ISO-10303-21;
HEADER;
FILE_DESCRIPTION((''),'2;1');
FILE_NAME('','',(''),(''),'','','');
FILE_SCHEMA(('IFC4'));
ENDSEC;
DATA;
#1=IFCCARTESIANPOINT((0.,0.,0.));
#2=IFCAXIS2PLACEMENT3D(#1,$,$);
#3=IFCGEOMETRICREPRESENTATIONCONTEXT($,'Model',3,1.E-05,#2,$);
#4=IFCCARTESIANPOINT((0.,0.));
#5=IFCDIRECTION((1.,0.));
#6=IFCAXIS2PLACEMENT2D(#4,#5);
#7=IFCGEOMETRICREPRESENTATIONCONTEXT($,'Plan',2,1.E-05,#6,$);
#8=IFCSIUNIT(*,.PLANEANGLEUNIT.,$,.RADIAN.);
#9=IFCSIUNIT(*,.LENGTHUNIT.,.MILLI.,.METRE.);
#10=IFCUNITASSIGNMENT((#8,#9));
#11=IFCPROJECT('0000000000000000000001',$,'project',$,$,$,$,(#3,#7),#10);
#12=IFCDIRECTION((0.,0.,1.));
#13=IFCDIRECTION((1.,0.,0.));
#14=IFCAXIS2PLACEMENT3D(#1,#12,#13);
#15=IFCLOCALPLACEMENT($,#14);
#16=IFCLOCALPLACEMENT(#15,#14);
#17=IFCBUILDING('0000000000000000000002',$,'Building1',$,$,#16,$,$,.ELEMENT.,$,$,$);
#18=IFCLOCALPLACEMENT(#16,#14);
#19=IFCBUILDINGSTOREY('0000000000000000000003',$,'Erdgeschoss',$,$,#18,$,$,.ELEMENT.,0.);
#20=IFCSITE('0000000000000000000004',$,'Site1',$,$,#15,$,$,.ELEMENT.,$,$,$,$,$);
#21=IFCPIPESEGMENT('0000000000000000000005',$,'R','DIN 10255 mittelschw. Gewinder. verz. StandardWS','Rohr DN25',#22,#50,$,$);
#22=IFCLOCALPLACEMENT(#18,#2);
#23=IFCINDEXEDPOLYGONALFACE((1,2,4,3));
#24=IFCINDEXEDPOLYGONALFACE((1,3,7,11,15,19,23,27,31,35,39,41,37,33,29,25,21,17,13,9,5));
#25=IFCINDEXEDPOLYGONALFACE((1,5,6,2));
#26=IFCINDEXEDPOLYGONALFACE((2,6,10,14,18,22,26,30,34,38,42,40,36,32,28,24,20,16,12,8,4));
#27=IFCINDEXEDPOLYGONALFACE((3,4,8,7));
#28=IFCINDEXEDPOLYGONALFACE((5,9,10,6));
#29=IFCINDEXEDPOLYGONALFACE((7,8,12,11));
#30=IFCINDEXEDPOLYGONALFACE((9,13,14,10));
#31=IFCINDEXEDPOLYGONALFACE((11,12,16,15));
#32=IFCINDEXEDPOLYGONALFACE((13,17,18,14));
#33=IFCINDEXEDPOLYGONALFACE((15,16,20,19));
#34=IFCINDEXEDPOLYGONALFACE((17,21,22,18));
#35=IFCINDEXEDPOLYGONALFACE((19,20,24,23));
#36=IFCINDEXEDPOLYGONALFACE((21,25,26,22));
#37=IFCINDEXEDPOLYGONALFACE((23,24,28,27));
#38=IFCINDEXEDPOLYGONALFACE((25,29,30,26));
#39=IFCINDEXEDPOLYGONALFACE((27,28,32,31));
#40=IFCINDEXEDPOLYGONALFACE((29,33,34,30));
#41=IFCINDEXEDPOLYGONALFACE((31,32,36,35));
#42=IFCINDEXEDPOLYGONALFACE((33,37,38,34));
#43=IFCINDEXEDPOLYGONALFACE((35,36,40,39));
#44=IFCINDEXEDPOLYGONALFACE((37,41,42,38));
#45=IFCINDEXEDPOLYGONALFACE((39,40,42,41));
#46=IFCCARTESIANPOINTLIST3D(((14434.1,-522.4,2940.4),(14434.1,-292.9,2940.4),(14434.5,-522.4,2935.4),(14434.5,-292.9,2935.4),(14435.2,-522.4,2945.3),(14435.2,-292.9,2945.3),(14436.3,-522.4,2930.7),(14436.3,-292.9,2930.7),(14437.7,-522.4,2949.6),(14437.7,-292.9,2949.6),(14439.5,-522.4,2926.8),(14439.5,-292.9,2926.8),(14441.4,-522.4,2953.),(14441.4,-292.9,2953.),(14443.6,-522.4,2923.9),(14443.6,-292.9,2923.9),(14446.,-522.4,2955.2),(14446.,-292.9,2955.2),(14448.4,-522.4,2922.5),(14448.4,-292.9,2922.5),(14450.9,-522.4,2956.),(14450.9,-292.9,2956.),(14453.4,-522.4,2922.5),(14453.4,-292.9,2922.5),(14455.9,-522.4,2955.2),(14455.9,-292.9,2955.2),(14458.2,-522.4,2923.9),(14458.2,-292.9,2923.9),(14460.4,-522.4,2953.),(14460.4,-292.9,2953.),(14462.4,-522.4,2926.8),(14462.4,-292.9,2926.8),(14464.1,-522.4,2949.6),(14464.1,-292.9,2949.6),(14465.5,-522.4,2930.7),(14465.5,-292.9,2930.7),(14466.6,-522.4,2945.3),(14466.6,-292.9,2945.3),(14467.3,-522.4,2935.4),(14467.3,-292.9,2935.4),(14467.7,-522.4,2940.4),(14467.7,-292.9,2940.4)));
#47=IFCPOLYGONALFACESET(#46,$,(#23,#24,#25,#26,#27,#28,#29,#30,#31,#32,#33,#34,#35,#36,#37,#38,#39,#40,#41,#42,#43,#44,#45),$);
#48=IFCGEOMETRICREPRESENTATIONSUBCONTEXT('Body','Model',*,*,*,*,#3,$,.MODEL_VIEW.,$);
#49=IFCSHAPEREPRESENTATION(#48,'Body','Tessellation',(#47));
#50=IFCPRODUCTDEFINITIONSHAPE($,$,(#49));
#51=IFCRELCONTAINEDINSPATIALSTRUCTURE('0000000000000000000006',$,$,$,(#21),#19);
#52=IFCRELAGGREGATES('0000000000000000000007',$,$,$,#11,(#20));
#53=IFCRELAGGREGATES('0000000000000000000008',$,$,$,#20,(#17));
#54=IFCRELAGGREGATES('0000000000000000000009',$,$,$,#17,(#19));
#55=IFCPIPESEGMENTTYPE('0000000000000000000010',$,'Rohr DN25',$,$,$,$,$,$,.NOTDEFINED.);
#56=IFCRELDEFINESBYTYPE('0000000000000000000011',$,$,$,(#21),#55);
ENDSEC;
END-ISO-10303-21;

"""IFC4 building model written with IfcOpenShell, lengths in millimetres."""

from ifc_helpers import new_model, si_unit, frame, origin, origin_with_axes, origin_2d_with_axis, place, context, subcontext, project, spatial, circle, extrude, type_object, element, save


model = new_model("IFC4")

# Units and contexts
model_context = context("Model", 3, precision=1e-05, world=origin())
plan_context = context("Plan", 2, precision=1e-05, world=origin_2d_with_axis())
body_context = subcontext(model_context, "Body", "Model", "MODEL_VIEW")
ifc_project = project(units=[si_unit("PLANEANGLEUNIT", "RADIAN"), si_unit("LENGTHUNIT", "METRE", prefix="MILLI")], contexts=[model_context, plan_context])

# Site, building, storey
site_placement = place(None, origin_with_axes())
site = spatial("IfcSite", under=ifc_project, at=site_placement, Name="Site1", CompositionType="ELEMENT")
building_placement = place(site_placement, origin_with_axes())
building = spatial("IfcBuilding", under=site, at=building_placement, Name="Building1", CompositionType="ELEMENT")
storey_placement = place(building_placement, origin_with_axes())
storey = spatial("IfcBuildingStorey", under=building, at=storey_placement, Name="Erdgeschoss", CompositionType="ELEMENT", Elevation=0.0)

# Pipe segment
pipe_segment_type_1 = type_object("IfcPipeSegmentType", Name="Rohr DN25", PredefinedType="NOTDEFINED")
pipe_segment_1_placement = place(storey_placement, frame((14450.8, -407.6, 2939.1), z_axis=(0.0, 0.0, 1.0), x_axis=(1.0, 0.0, 0.0)))
element("IfcPipeSegment", 1, at=pipe_segment_1_placement, inside=storey, type_object=pipe_segment_type_1, Name="R", Description="DIN 10255 mittelschw. Gewinder. verz. StandardWS", ObjectType="Rohr DN25", context=body_context, shape_type="SolidModel", body=[
    extrude(circle(Radius=16.9, at=origin_2d_with_axis()), frame((0.2, -114.8, 0.0), z_axis=(-0.000001, 1.0, 0.0), x_axis=(0.0, 0.0, 1.0)), (0.0, 0.0, 1.0), 229.5),
])

save(model, "model.ifc")
